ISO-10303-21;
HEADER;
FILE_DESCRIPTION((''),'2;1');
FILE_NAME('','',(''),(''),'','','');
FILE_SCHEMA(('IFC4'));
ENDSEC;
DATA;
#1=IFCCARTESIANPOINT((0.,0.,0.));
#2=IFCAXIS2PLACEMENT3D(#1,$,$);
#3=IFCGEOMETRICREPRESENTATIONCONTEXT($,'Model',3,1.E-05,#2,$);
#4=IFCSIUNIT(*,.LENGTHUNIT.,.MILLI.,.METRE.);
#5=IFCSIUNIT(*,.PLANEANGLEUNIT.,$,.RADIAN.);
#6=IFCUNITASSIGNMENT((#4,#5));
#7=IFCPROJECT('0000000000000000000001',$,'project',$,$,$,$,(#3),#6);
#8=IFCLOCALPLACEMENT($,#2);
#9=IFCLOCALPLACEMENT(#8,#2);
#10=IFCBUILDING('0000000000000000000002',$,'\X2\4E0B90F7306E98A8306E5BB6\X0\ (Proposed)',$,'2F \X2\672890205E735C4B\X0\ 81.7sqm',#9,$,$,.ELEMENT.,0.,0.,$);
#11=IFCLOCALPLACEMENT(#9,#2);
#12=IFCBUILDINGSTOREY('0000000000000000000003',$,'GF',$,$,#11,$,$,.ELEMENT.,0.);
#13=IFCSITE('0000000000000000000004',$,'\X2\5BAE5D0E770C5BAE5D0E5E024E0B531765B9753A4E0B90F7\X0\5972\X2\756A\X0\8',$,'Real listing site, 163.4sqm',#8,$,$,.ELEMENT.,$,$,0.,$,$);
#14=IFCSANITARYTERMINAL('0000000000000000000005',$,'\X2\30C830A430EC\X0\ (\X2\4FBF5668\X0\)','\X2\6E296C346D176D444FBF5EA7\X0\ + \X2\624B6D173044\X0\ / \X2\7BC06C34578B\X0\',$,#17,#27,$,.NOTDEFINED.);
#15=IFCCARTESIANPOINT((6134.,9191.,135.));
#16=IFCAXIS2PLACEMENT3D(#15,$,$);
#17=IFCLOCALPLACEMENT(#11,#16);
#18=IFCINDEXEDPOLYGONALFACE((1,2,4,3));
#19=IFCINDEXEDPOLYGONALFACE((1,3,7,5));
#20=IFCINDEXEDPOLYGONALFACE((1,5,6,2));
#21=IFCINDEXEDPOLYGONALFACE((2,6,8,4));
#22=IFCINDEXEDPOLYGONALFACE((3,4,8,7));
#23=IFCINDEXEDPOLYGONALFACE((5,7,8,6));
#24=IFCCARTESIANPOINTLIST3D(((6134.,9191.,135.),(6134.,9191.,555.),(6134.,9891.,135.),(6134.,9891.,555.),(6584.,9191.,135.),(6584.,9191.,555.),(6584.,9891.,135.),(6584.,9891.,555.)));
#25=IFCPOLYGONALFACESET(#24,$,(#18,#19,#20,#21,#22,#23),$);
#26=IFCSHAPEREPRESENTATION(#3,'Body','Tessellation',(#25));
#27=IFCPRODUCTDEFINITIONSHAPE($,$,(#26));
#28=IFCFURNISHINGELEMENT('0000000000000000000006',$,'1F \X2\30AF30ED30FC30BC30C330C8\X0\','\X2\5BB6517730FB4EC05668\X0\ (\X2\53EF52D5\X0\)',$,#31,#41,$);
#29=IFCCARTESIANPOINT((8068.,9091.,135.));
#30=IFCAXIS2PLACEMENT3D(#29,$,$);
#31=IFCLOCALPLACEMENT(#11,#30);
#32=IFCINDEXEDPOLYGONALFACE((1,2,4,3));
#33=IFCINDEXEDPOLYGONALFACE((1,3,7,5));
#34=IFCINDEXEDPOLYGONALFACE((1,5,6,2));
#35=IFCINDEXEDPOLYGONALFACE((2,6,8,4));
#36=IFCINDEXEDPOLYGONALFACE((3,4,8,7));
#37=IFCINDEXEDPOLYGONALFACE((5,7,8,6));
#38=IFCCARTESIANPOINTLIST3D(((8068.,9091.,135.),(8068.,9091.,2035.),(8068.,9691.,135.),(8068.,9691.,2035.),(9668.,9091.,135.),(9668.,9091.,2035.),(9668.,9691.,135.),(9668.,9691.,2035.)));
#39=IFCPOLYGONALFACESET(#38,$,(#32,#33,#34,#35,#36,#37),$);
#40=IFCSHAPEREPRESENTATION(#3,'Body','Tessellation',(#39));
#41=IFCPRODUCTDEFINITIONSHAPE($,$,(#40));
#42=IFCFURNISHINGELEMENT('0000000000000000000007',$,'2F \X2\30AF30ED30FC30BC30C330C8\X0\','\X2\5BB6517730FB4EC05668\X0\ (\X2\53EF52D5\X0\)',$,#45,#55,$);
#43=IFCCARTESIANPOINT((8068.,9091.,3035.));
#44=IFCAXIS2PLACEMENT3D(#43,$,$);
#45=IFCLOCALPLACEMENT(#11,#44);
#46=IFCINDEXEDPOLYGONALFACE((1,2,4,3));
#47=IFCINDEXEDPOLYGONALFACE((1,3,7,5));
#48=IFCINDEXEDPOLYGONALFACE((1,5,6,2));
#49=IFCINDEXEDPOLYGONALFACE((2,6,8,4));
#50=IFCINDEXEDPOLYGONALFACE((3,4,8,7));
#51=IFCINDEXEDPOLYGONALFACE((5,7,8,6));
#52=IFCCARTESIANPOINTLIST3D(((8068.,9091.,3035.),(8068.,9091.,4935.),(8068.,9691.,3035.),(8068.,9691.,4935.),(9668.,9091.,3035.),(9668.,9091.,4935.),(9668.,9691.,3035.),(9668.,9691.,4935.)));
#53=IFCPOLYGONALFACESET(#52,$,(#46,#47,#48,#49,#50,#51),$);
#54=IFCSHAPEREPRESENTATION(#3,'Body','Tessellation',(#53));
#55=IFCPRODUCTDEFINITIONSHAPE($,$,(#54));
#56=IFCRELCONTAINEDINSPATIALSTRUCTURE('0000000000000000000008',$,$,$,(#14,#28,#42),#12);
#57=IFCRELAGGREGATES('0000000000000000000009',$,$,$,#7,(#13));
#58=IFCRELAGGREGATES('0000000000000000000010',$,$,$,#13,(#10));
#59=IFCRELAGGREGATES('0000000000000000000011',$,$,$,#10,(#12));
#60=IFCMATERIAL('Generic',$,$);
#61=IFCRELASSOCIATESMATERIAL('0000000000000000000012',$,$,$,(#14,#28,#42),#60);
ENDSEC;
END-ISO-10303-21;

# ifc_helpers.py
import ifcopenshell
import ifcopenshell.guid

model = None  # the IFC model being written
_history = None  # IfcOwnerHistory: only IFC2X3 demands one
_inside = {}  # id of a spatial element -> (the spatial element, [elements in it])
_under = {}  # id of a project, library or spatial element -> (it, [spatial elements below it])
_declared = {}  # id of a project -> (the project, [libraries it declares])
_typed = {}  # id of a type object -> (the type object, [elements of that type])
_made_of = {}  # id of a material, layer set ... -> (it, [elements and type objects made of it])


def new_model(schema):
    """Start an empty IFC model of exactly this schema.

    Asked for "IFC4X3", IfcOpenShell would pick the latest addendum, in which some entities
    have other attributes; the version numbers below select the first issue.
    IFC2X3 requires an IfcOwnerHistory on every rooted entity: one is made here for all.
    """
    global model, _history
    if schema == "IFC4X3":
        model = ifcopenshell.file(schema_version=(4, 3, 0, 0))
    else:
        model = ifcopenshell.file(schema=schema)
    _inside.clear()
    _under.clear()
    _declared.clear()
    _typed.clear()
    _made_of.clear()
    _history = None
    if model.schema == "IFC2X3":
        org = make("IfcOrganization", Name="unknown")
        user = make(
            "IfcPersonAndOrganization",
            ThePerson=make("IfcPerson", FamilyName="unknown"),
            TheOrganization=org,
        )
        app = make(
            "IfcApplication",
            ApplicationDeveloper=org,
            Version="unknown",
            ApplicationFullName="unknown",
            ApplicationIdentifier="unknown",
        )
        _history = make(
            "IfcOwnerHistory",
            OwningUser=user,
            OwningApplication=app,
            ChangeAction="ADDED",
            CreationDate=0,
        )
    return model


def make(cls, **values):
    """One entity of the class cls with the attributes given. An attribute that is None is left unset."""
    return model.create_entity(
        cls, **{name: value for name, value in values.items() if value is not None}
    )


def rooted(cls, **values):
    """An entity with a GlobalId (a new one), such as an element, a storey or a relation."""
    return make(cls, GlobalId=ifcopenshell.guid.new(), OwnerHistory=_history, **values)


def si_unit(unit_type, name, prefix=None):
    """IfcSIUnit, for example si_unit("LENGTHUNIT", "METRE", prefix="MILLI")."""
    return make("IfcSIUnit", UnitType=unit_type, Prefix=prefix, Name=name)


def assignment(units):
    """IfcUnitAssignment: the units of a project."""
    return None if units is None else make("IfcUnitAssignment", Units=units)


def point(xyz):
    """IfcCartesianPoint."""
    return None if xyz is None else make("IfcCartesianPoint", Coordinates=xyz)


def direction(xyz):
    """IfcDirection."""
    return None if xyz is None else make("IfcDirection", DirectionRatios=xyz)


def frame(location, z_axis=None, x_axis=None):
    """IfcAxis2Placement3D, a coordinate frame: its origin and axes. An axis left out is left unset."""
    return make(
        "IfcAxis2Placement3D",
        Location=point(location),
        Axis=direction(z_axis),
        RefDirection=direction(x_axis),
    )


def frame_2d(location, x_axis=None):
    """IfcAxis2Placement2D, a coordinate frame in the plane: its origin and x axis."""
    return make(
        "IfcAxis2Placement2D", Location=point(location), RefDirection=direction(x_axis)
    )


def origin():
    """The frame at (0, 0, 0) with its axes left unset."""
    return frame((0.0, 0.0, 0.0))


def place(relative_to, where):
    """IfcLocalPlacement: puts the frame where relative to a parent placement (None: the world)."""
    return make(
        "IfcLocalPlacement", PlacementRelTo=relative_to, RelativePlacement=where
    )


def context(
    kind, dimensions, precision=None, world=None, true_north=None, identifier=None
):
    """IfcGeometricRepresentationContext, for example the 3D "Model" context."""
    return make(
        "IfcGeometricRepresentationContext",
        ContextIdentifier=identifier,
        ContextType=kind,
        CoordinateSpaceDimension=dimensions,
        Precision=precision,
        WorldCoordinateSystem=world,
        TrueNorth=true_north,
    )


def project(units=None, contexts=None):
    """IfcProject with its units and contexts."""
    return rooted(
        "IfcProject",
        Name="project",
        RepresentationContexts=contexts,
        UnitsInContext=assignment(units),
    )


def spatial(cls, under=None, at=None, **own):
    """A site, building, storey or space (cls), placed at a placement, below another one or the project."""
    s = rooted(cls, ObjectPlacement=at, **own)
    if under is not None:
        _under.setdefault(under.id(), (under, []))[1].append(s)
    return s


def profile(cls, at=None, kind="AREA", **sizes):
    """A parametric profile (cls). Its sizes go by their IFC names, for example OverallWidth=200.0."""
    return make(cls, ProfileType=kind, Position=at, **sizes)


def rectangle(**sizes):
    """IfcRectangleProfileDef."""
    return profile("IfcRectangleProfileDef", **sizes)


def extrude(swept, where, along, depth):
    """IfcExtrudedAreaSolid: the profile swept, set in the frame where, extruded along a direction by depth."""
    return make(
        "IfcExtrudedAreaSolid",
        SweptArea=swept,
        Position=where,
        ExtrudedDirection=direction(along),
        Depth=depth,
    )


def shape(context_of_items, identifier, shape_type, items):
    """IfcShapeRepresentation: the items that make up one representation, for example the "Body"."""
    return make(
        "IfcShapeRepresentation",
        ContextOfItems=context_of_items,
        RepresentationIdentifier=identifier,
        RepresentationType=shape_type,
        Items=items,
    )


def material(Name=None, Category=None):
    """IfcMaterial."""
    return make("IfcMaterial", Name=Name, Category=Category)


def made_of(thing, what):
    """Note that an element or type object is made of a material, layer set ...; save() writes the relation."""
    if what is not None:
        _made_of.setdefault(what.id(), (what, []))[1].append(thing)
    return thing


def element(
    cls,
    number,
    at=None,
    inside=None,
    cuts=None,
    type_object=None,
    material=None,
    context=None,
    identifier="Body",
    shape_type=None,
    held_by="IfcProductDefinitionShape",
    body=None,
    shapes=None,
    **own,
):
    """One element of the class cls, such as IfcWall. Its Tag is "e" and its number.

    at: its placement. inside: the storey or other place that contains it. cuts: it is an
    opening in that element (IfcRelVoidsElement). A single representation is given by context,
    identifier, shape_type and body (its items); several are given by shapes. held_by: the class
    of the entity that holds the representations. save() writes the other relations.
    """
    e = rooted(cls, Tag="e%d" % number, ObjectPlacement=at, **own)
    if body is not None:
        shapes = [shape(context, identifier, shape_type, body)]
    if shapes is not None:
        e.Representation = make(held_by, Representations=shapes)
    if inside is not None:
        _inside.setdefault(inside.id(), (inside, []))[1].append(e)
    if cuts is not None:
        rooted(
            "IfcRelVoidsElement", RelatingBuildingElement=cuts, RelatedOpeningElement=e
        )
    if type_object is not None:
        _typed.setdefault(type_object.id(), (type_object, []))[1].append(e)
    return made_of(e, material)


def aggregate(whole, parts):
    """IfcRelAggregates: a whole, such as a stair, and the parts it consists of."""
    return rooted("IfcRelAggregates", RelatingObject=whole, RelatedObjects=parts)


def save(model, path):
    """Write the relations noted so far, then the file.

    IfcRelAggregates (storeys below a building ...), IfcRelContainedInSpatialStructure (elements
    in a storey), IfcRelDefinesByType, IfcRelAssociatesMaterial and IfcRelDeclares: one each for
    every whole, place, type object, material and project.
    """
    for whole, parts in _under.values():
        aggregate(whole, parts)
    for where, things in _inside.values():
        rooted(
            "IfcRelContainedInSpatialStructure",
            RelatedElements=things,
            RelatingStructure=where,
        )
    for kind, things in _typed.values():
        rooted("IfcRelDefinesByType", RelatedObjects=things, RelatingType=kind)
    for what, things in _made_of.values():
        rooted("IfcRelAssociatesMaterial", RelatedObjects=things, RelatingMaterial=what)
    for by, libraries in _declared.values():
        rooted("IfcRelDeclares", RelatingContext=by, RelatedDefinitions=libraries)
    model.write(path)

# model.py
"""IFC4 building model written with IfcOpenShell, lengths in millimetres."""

from ifc_helpers import new_model, si_unit, frame, frame_2d, origin, place, context, project, spatial, rectangle, extrude, material, element, save


model = new_model("IFC4")

# Units and contexts
model_context = context("Model", 3, precision=1e-05, world=origin())
ifc_project = project(units=[si_unit("LENGTHUNIT", "METRE", prefix="MILLI"), si_unit("PLANEANGLEUNIT", "RADIAN")], contexts=[model_context])

# Site, building, storey
site_placement = place(None, origin())
site = spatial("IfcSite", under=ifc_project, at=site_placement, Name="宮崎県宮崎市下北方町下郷5972番8", ObjectType="Real listing site, 163.4sqm", CompositionType="ELEMENT", RefElevation=0.0)
building_placement = place(site_placement, origin())
building = spatial("IfcBuilding", under=site, at=building_placement, Name="下郷の風の家 (Proposed)", ObjectType="2F 木造平屋 81.7sqm", CompositionType="ELEMENT", ElevationOfRefHeight=0.0, ElevationOfTerrain=0.0)
storey_placement = place(building_placement, origin())
storey = spatial("IfcBuildingStorey", under=building, at=storey_placement, Name="GF", CompositionType="ELEMENT", Elevation=0.0)

# Shared definitions
ifc_material_1 = material(Name="Generic")

# Sanitary terminal
sanitary_terminal_1_placement = place(storey_placement, frame((6134.0, 9191.0, 135.0)))
element("IfcSanitaryTerminal", 1, at=sanitary_terminal_1_placement, inside=storey, material=ifc_material_1, Name="トイレ (便器)", Description="温水洗浄便座 + 手洗い / 節水型", PredefinedType="NOTDEFINED", context=model_context, shape_type="SweptSolid", body=[
    extrude(rectangle(XDim=450.0, YDim=700.0, at=frame_2d((225.0, 350.0))), frame((6134.0, 9191.0, 135.0)), (0.0, 0.0, 1.0), 420.0),
])

# Furnishing elements
furnishing_1_placement = place(storey_placement, frame((8068.0, 9091.0, 135.0)))
element("IfcFurnishingElement", 2, at=furnishing_1_placement, inside=storey, material=ifc_material_1, Name="1F クローゼット", Description="家具・什器 (可動)", context=model_context, shape_type="SweptSolid", body=[
    extrude(rectangle(XDim=1600.0, YDim=600.0, at=frame_2d((800.0, 300.0))), frame((8068.0, 9091.0, 135.0)), (0.0, 0.0, 1.0), 1900.0),
])
furnishing_2_placement = place(storey_placement, frame((8068.0, 9091.0, 3035.0)))
element("IfcFurnishingElement", 3, at=furnishing_2_placement, inside=storey, material=ifc_material_1, Name="2F クローゼット", Description="家具・什器 (可動)", context=model_context, shape_type="SweptSolid", body=[
    extrude(rectangle(XDim=1600.0, YDim=600.0, at=frame_2d((800.0, 300.0))), frame((8068.0, 9091.0, 3035.0)), (0.0, 0.0, 1.0), 1900.0),
])

save(model, "model.ifc")
